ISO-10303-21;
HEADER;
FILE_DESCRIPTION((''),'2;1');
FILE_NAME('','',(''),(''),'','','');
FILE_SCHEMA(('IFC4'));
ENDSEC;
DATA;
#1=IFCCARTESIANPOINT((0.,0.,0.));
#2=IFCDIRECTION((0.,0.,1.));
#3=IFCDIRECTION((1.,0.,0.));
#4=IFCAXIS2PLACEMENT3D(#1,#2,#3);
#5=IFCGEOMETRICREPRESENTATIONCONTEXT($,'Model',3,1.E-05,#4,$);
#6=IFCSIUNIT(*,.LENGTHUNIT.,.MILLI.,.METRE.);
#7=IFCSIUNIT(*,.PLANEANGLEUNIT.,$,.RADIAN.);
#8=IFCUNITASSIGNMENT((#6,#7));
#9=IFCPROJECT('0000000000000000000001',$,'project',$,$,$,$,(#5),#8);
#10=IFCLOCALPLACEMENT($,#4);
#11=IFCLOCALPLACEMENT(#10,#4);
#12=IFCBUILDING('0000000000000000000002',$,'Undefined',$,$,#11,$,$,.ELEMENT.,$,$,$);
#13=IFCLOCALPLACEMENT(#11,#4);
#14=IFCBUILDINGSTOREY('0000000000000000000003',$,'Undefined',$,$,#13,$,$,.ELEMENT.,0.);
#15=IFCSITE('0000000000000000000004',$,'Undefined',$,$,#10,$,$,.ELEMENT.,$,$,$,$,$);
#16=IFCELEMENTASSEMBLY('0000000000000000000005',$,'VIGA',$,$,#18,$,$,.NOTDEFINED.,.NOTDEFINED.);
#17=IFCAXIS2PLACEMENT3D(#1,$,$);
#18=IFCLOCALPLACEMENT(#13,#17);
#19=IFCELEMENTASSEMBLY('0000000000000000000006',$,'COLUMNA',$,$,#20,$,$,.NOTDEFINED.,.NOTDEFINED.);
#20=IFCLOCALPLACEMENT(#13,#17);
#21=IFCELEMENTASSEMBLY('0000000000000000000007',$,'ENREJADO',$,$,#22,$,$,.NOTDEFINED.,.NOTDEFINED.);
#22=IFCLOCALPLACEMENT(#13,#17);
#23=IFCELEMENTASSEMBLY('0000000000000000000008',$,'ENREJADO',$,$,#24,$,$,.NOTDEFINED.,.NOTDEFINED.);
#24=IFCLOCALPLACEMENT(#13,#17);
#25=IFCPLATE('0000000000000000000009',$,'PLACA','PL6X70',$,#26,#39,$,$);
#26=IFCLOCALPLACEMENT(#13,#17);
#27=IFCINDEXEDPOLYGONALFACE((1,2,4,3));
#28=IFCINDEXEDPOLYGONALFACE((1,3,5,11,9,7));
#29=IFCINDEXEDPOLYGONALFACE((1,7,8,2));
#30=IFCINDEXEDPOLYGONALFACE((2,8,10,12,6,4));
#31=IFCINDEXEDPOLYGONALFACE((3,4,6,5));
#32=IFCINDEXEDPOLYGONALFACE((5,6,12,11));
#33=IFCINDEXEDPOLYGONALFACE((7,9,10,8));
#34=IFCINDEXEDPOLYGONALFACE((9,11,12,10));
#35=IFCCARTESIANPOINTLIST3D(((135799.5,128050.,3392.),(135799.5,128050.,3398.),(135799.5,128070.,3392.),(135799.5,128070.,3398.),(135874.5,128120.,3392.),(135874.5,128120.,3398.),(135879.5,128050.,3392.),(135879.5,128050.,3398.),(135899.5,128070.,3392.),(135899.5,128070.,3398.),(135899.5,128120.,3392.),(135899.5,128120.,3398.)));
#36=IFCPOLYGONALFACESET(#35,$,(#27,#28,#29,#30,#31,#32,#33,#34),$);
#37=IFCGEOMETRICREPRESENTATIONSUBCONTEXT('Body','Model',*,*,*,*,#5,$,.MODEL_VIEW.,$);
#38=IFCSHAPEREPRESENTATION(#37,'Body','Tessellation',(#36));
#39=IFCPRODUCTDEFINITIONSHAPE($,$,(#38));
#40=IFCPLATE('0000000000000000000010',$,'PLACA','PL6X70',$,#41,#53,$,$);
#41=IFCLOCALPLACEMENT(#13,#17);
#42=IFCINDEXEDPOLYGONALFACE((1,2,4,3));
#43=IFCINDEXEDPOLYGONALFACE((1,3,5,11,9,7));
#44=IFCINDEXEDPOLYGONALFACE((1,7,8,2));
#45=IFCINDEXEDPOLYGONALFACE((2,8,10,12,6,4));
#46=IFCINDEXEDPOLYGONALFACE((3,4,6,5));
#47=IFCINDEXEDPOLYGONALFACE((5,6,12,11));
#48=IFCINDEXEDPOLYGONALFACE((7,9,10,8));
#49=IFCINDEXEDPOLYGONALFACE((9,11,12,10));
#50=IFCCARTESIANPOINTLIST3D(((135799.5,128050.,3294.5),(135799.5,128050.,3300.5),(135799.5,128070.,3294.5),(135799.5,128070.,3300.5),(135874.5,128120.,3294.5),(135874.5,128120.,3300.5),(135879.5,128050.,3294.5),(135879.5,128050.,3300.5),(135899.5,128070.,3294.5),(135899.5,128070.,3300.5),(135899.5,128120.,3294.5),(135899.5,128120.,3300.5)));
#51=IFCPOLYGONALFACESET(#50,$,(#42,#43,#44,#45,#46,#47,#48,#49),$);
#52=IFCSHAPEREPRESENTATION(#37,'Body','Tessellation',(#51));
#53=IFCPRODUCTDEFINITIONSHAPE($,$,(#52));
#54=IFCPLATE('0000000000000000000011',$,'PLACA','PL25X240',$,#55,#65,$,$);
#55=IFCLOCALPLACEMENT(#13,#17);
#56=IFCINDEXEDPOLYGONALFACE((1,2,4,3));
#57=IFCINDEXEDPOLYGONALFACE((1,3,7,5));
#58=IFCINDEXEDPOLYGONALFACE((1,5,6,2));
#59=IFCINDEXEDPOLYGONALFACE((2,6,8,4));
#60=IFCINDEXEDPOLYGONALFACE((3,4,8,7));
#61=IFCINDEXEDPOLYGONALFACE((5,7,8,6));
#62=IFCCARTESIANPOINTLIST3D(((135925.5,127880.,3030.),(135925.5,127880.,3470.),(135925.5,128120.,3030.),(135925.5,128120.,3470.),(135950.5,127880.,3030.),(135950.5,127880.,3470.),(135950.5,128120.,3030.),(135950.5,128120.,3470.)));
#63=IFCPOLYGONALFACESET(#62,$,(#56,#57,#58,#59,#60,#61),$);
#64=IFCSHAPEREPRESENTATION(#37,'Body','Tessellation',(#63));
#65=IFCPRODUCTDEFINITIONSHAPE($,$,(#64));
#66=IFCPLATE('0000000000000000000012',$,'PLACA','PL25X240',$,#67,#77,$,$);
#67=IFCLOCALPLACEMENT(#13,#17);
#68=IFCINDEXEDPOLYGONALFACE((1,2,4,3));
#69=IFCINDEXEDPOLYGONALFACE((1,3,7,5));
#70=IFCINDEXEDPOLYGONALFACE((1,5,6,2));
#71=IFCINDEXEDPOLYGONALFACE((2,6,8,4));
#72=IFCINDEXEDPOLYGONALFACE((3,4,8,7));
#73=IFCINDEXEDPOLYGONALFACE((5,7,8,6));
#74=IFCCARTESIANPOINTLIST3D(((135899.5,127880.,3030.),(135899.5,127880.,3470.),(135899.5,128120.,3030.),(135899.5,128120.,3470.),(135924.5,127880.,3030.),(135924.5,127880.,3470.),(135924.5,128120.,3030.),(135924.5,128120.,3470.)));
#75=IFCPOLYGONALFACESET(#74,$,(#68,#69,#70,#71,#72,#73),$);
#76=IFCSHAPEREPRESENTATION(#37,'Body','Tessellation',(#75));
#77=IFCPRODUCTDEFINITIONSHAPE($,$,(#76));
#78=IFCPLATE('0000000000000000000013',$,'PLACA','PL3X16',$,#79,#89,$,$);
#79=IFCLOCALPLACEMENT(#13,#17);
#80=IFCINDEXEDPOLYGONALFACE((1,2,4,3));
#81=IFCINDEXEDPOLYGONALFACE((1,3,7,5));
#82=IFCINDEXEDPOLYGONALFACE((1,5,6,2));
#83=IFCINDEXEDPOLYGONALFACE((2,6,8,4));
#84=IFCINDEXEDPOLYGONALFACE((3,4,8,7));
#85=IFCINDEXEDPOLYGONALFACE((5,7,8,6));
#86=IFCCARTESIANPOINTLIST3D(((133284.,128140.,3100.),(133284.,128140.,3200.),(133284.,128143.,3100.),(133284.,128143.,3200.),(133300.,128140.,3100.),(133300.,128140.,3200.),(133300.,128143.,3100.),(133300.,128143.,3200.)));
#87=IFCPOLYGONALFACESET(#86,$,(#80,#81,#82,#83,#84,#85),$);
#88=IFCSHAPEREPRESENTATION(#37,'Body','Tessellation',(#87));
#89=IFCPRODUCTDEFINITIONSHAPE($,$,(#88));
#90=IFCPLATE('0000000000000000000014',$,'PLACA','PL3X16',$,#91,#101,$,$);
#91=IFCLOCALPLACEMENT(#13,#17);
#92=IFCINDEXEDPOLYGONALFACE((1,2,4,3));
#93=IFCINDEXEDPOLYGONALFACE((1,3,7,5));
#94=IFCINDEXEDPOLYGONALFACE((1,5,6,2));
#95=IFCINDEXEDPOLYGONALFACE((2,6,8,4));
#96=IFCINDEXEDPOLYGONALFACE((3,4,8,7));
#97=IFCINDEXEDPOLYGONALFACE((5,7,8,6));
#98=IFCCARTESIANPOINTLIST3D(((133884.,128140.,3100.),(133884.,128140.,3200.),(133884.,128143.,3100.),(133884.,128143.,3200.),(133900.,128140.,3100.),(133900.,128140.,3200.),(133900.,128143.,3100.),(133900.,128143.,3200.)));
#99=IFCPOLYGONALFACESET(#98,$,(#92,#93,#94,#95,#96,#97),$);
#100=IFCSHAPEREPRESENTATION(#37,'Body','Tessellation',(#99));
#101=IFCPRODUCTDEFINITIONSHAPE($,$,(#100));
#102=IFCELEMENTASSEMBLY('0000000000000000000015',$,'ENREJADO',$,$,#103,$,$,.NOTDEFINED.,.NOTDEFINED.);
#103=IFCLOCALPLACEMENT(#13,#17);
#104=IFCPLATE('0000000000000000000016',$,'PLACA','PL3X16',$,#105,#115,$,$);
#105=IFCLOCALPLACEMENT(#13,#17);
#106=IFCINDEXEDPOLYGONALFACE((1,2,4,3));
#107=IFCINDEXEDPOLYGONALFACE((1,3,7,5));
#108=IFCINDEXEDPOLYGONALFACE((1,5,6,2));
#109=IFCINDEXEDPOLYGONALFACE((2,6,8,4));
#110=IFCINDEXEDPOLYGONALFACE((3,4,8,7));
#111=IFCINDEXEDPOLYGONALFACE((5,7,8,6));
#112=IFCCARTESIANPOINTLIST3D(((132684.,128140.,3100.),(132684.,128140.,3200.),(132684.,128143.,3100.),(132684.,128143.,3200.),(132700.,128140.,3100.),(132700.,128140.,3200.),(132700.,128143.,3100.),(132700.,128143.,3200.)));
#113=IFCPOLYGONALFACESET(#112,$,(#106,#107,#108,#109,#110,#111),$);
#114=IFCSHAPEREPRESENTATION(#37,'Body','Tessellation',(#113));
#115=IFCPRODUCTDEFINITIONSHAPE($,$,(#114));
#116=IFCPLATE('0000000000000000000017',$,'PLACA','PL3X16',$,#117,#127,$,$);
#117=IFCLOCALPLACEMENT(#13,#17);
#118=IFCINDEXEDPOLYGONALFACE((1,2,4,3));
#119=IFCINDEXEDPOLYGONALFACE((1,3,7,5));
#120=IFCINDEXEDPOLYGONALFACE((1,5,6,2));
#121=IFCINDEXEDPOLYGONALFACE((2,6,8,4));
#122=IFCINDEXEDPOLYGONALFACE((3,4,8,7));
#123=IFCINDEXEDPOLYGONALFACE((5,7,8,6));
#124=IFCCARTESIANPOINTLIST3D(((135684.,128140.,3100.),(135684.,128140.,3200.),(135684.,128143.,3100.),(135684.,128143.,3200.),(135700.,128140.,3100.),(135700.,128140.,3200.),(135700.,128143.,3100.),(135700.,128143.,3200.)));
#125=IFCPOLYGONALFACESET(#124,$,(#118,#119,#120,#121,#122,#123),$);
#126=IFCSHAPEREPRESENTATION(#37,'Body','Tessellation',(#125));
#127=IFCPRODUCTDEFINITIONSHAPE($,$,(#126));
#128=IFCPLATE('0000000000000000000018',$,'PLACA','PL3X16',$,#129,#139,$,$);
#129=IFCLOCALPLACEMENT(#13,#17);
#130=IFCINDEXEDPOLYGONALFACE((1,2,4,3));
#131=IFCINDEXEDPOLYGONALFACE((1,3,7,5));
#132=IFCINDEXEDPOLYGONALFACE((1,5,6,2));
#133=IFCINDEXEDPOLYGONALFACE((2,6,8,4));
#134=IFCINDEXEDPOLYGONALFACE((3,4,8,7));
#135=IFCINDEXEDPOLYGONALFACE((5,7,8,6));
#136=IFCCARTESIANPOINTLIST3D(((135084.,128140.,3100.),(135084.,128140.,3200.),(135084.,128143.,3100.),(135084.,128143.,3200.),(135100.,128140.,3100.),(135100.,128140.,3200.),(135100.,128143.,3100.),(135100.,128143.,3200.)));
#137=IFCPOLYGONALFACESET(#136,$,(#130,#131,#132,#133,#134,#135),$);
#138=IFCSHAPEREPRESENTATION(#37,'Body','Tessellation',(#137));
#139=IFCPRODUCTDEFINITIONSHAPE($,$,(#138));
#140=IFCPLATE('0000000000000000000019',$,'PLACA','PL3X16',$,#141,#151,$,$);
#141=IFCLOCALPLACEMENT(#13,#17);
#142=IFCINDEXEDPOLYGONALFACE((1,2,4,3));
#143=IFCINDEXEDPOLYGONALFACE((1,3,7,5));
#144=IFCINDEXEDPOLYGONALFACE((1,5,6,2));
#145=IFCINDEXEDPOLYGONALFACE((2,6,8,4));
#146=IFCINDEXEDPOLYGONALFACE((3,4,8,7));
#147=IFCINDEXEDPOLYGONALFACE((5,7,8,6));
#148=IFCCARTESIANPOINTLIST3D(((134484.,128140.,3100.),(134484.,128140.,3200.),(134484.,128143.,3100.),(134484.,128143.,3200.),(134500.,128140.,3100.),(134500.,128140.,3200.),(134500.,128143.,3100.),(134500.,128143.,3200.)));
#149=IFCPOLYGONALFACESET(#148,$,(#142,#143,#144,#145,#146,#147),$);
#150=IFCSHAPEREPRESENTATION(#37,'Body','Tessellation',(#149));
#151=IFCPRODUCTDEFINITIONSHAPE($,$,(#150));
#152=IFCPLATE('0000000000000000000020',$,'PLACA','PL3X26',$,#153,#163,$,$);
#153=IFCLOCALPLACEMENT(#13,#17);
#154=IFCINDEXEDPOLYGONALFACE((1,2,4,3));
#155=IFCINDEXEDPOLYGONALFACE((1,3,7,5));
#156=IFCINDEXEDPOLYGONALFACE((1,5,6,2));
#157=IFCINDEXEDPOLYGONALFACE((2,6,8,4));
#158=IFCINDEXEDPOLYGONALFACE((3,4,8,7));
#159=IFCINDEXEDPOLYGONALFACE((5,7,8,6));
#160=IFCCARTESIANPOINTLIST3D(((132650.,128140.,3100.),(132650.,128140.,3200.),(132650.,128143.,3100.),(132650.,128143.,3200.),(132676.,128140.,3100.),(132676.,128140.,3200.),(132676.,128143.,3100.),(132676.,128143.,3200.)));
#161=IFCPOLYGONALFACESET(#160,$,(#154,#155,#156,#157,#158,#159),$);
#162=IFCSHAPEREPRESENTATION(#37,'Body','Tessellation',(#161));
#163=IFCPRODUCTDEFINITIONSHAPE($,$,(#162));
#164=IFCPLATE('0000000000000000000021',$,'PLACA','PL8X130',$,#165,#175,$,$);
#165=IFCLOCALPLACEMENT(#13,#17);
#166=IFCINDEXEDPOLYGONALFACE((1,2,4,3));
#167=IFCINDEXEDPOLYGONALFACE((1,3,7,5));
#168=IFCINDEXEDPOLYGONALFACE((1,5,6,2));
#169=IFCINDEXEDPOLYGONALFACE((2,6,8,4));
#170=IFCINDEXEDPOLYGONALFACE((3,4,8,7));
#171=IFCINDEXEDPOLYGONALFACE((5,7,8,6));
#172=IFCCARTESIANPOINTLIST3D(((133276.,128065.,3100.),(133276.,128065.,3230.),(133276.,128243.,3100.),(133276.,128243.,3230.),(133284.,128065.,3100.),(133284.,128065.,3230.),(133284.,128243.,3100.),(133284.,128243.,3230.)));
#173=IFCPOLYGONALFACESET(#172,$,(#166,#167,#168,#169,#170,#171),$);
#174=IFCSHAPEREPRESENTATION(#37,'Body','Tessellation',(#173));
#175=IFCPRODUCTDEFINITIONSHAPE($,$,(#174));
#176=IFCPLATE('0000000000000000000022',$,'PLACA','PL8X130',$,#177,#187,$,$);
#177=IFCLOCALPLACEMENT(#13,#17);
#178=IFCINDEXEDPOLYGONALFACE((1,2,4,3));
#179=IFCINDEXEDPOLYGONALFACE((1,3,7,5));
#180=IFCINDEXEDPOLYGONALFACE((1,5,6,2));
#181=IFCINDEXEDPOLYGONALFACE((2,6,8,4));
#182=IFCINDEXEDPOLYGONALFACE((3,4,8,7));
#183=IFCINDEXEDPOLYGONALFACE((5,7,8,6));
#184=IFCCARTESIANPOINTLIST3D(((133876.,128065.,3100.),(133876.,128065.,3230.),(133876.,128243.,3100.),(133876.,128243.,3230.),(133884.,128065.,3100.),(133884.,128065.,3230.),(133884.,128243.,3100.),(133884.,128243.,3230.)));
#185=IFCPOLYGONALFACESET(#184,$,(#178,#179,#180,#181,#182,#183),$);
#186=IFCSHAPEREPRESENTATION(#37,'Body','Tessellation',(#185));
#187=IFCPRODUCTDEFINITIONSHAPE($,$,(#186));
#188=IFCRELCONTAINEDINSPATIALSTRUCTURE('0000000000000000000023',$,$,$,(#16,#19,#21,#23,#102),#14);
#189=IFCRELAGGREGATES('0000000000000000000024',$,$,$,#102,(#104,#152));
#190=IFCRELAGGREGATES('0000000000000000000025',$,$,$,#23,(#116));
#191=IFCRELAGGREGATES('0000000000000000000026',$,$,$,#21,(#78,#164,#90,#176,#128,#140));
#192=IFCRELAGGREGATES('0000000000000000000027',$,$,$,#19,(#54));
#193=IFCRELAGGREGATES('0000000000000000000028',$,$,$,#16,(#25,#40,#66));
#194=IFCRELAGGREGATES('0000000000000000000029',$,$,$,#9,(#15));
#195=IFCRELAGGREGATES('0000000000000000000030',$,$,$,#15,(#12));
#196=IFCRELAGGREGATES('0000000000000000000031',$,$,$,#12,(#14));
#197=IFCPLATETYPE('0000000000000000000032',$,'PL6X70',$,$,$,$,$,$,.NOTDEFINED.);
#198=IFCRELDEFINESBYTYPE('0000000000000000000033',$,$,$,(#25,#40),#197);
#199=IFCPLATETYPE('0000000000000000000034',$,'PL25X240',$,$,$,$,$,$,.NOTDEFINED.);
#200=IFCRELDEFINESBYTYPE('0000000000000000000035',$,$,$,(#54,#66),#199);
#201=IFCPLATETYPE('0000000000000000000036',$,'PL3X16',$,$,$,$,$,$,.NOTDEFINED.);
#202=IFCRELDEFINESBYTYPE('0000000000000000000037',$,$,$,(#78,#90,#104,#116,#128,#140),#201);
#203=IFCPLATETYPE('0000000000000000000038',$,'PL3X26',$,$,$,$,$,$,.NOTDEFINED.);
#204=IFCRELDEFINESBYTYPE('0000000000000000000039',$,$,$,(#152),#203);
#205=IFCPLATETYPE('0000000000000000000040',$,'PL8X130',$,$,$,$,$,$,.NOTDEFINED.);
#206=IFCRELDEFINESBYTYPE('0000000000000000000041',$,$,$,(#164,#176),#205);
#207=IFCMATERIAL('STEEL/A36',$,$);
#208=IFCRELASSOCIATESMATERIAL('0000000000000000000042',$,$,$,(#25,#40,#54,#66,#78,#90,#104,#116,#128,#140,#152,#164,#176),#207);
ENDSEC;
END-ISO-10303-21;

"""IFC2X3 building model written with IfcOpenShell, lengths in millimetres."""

from ifc_helpers import new_model, si_unit, frame, origin_with_axes, place, context, subcontext, project, spatial, polyline, outline, extrude, material, type_object, element, aggregate, save


model = new_model("IFC2X3")

# Units and contexts
model_context = context("Model", 3, precision=1e-05, world=origin_with_axes())
body_context = subcontext(model_context, "Body", "Model", "MODEL_VIEW")
ifc_project = project(units=[si_unit("LENGTHUNIT", "METRE", prefix="MILLI"), si_unit("PLANEANGLEUNIT", "RADIAN")], contexts=[model_context])

# Site, building, storey
site_placement = place(None, origin_with_axes())
site = spatial("IfcSite", under=ifc_project, at=site_placement, Name="Undefined", CompositionType="ELEMENT")
building_placement = place(site_placement, origin_with_axes())
building = spatial("IfcBuilding", under=site, at=building_placement, Name="Undefined", CompositionType="ELEMENT")
storey_placement = place(building_placement, origin_with_axes())
storey = spatial("IfcBuildingStorey", under=building, at=storey_placement, Name="Undefined", CompositionType="ELEMENT", Elevation=0.0)

# Element assembly
assembly_1_placement = place(storey_placement, origin_with_axes())
assembly_1 = element("IfcElementAssembly", 1, at=assembly_1_placement, inside=storey, Name="VIGA", AssemblyPlace="NOTDEFINED", PredefinedType="NOTDEFINED")
ifc_material_1 = material(Name="STEEL/A36")

# Element assembly
assembly_2_placement = place(storey_placement, origin_with_axes())
assembly_2 = element("IfcElementAssembly", 2, at=assembly_2_placement, inside=storey, Name="COLUMNA", AssemblyPlace="NOTDEFINED", PredefinedType="NOTDEFINED")

# Element assembly
assembly_3_placement = place(storey_placement, origin_with_axes())
assembly_3 = element("IfcElementAssembly", 3, at=assembly_3_placement, inside=storey, Name="ENREJADO", AssemblyPlace="NOTDEFINED", PredefinedType="NOTDEFINED")

# Element assembly
assembly_4_placement = place(storey_placement, origin_with_axes())
assembly_4 = element("IfcElementAssembly", 4, at=assembly_4_placement, inside=storey, Name="ENREJADO", AssemblyPlace="NOTDEFINED", PredefinedType="NOTDEFINED")

# Plates
plate_type_1 = type_object("IfcPlateType", Name="PL6X70", PredefinedType="NOTDEFINED")
plate_1_placement = place(assembly_1_placement, frame((135899.5, 128120.0, 3395.0), z_axis=(0.0, 0.0, 1.0), x_axis=(-1.0, 0.0, 0.0)))
plate_1 = element("IfcPlate", 5, at=plate_1_placement, type_object=plate_type_1, material=ifc_material_1, Name="PLACA", Description="PL6X70", context=body_context, shape_type="SweptSolid", body=[
    extrude(outline(polyline([(0.0, 0.0), (25.0, 0.0), (100.0, 50.0), (100.0, 70.0), (20.0, 70.0), (0.0, 50.0), (0.0, 0.0)])), frame((0.0, 0.0, -3.0), z_axis=(0.0, 0.0, 1.0), x_axis=(1.0, 0.0, 0.0)), (0.0, 0.0, 1.0), 6.0),
])
plate_2_placement = place(assembly_1_placement, frame((135899.5, 128120.0, 3297.5), z_axis=(0.0, 0.0, 1.0), x_axis=(-1.0, 0.0, 0.0)))
plate_2 = element("IfcPlate", 6, at=plate_2_placement, type_object=plate_type_1, material=ifc_material_1, Name="PLACA", Description="PL6X70", context=body_context, shape_type="SweptSolid", body=[
    extrude(outline(polyline([(0.0, 0.0), (25.0, 0.0), (100.0, 50.0), (100.0, 70.0), (20.0, 70.0), (0.0, 50.0), (0.0, 0.0)])), frame((0.0, 0.0, -3.0), z_axis=(0.0, 0.0, 1.0), x_axis=(1.0, 0.0, 0.0)), (0.0, 0.0, 1.0), 6.0),
])
plate_type_2 = type_object("IfcPlateType", Name="PL25X240", PredefinedType="NOTDEFINED")
plate_3_placement = place(assembly_2_placement, frame((135938.0, 128000.0, 3030.0), z_axis=(1.0, 0.0, 0.0), x_axis=(0.0, 0.0, 1.0)))
plate_3 = element("IfcPlate", 7, at=plate_3_placement, type_object=plate_type_2, material=ifc_material_1, Name="PLACA", Description="PL25X240", context=body_context, shape_type="SweptSolid", body=[
    extrude(outline(polyline([(0.0, -120.0), (0.0, 120.0), (440.0, 120.0), (440.0, -120.0), (0.0, -120.0)])), frame((0.0, 0.0, -12.5), z_axis=(0.0, 0.0, 1.0), x_axis=(1.0, 0.0, 0.0)), (0.0, 0.0, 1.0), 25.0),
])
plate_4_placement = place(assembly_1_placement, frame((135912.0, 128000.0, 3030.0), z_axis=(1.0, 0.0, 0.0), x_axis=(0.0, 0.0, 1.0)))
plate_4 = element("IfcPlate", 8, at=plate_4_placement, type_object=plate_type_2, material=ifc_material_1, Name="PLACA", Description="PL25X240", context=body_context, shape_type="SweptSolid", body=[
    extrude(outline(polyline([(0.0, -120.0), (0.0, 120.0), (440.0, 120.0), (440.0, -120.0), (0.0, -120.0)])), frame((0.0, 0.0, -12.5), z_axis=(0.0, 0.0, 1.0), x_axis=(1.0, 0.0, 0.0)), (0.0, 0.0, 1.0), 25.0),
])
plate_type_3 = type_object("IfcPlateType", Name="PL3X16", PredefinedType="NOTDEFINED")
plate_5_placement = place(assembly_3_placement, frame((133300.0, 128141.5, 3100.0), z_axis=(0.000001, 1.0, 0.0), x_axis=(-1.0, 0.000001, 0.0)))
plate_5 = element("IfcPlate", 9, at=plate_5_placement, type_object=plate_type_3, material=ifc_material_1, Name="PLACA", Description="PL3X16", context=body_context, shape_type="SweptSolid", body=[
    extrude(outline(polyline([(0.0, 0.0), (16.0, 0.0), (16.0, 100.0), (0.0, 100.0), (0.0, 0.0)])), frame((0.0, 0.0, -1.5), z_axis=(0.0, 0.0, 1.0), x_axis=(1.0, 0.0, 0.0)), (0.0, 0.0, 1.0), 3.0),
])
plate_6_placement = place(assembly_3_placement, frame((133900.0, 128141.5, 3100.0), z_axis=(0.000001, 1.0, 0.0), x_axis=(-1.0, 0.000001, 0.0)))
plate_6 = element("IfcPlate", 10, at=plate_6_placement, type_object=plate_type_3, material=ifc_material_1, Name="PLACA", Description="PL3X16", context=body_context, shape_type="SweptSolid", body=[
    extrude(outline(polyline([(0.0, 0.0), (16.0, 0.0), (16.0, 100.0), (0.0, 100.0), (0.0, 0.0)])), frame((0.0, 0.0, -1.5), z_axis=(0.0, 0.0, 1.0), x_axis=(1.0, 0.0, 0.0)), (0.0, 0.0, 1.0), 3.0),
])

# Element assembly, plate
assembly_5_placement = place(storey_placement, origin_with_axes())
assembly_5 = element("IfcElementAssembly", 11, at=assembly_5_placement, inside=storey, Name="ENREJADO", AssemblyPlace="NOTDEFINED", PredefinedType="NOTDEFINED")
plate_7_placement = place(assembly_5_placement, frame((132700.0, 128141.5, 3100.0), z_axis=(0.000001, 1.0, 0.0), x_axis=(-1.0, 0.000001, 0.0)))
plate_7 = element("IfcPlate", 12, at=plate_7_placement, type_object=plate_type_3, material=ifc_material_1, Name="PLACA", Description="PL3X16", context=body_context, shape_type="SweptSolid", body=[
    extrude(outline(polyline([(0.0, 0.0), (16.0, 0.0), (16.0, 100.0), (0.0, 100.0), (0.0, 0.0)])), frame((0.0, 0.0, -1.5), z_axis=(0.0, 0.0, 1.0), x_axis=(1.0, 0.0, 0.0)), (0.0, 0.0, 1.0), 3.0),
])

# Plates
plate_8_placement = place(assembly_4_placement, frame((135700.0, 128141.5, 3100.0), z_axis=(0.000001, 1.0, 0.0), x_axis=(-1.0, 0.000001, 0.0)))
plate_8 = element("IfcPlate", 13, at=plate_8_placement, type_object=plate_type_3, material=ifc_material_1, Name="PLACA", Description="PL3X16", context=body_context, shape_type="SweptSolid", body=[
    extrude(outline(polyline([(0.0, 0.0), (16.0, 0.0), (16.0, 100.0), (0.0, 100.0), (0.0, 0.0)])), frame((0.0, 0.0, -1.5), z_axis=(0.0, 0.0, 1.0), x_axis=(1.0, 0.0, 0.0)), (0.0, 0.0, 1.0), 3.0),
])
plate_9_placement = place(assembly_3_placement, frame((135100.0, 128141.5, 3100.0), z_axis=(0.000001, 1.0, 0.0), x_axis=(-1.0, 0.000001, 0.0)))
plate_9 = element("IfcPlate", 14, at=plate_9_placement, type_object=plate_type_3, material=ifc_material_1, Name="PLACA", Description="PL3X16", context=body_context, shape_type="SweptSolid", body=[
    extrude(outline(polyline([(0.0, 0.0), (16.0, 0.0), (16.0, 100.0), (0.0, 100.0), (0.0, 0.0)])), frame((0.0, 0.0, -1.5), z_axis=(0.0, 0.0, 1.0), x_axis=(1.0, 0.0, 0.0)), (0.0, 0.0, 1.0), 3.0),
])
plate_10_placement = place(assembly_3_placement, frame((134500.0, 128141.5, 3100.0), z_axis=(0.000001, 1.0, 0.0), x_axis=(-1.0, 0.000001, 0.0)))
plate_10 = element("IfcPlate", 15, at=plate_10_placement, type_object=plate_type_3, material=ifc_material_1, Name="PLACA", Description="PL3X16", context=body_context, shape_type="SweptSolid", body=[
    extrude(outline(polyline([(0.0, 0.0), (16.0, 0.0), (16.0, 100.0), (0.0, 100.0), (0.0, 0.0)])), frame((0.0, 0.0, -1.5), z_axis=(0.0, 0.0, 1.0), x_axis=(1.0, 0.0, 0.0)), (0.0, 0.0, 1.0), 3.0),
])
plate_type_4 = type_object("IfcPlateType", Name="PL3X26", PredefinedType="NOTDEFINED")
plate_11_placement = place(assembly_5_placement, frame((132676.0, 128141.5, 3100.0), z_axis=(0.000001, 1.0, 0.0), x_axis=(-1.0, 0.000001, 0.0)))
plate_11 = element("IfcPlate", 16, at=plate_11_placement, type_object=plate_type_4, material=ifc_material_1, Name="PLACA", Description="PL3X26", context=body_context, shape_type="SweptSolid", body=[
    extrude(outline(polyline([(0.0, 0.0), (26.0, 0.0), (26.0, 100.0), (0.0, 100.0), (0.0, 0.0)])), frame((0.0, 0.0, -1.5), z_axis=(0.0, 0.0, 1.0), x_axis=(1.0, 0.0, 0.0)), (0.0, 0.0, 1.0), 3.0),
])
plate_type_5 = type_object("IfcPlateType", Name="PL8X130", PredefinedType="NOTDEFINED")
plate_12_placement = place(assembly_3_placement, frame((133280.0, 128065.0, 3165.0), z_axis=(-1.0, 0.000001, 0.0), x_axis=(0.000001, 1.0, 0.0)))
plate_12 = element("IfcPlate", 17, at=plate_12_placement, type_object=plate_type_5, material=ifc_material_1, Name="PLACA", Description="PL8X130", context=body_context, shape_type="SweptSolid", body=[
    extrude(outline(polyline([(0.0, -65.0), (0.0, 65.0), (178.0, 65.0), (178.0, -65.0), (0.0, -65.0)])), frame((0.0, 0.0, -4.0), z_axis=(0.0, 0.0, 1.0), x_axis=(1.0, 0.0, 0.0)), (0.0, 0.0, 1.0), 8.0),
])
plate_13_placement = place(assembly_3_placement, frame((133880.0, 128065.0, 3165.0), z_axis=(-1.0, 0.000001, 0.0), x_axis=(0.000001, 1.0, 0.0)))
plate_13 = element("IfcPlate", 18, at=plate_13_placement, type_object=plate_type_5, material=ifc_material_1, Name="PLACA", Description="PL8X130", context=body_context, shape_type="SweptSolid", body=[
    extrude(outline(polyline([(0.0, -65.0), (0.0, 65.0), (178.0, 65.0), (178.0, -65.0), (0.0, -65.0)])), frame((0.0, 0.0, -4.0), z_axis=(0.0, 0.0, 1.0), x_axis=(1.0, 0.0, 0.0)), (0.0, 0.0, 1.0), 8.0),
])
aggregate(assembly_5, [plate_7, plate_11])
aggregate(assembly_4, [plate_8])
aggregate(assembly_3, [plate_5, plate_12, plate_6, plate_13, plate_9, plate_10])

aggregate(assembly_2, [plate_3])
aggregate(assembly_1, [plate_1, plate_2, plate_4])

save(model, "model.ifc")
